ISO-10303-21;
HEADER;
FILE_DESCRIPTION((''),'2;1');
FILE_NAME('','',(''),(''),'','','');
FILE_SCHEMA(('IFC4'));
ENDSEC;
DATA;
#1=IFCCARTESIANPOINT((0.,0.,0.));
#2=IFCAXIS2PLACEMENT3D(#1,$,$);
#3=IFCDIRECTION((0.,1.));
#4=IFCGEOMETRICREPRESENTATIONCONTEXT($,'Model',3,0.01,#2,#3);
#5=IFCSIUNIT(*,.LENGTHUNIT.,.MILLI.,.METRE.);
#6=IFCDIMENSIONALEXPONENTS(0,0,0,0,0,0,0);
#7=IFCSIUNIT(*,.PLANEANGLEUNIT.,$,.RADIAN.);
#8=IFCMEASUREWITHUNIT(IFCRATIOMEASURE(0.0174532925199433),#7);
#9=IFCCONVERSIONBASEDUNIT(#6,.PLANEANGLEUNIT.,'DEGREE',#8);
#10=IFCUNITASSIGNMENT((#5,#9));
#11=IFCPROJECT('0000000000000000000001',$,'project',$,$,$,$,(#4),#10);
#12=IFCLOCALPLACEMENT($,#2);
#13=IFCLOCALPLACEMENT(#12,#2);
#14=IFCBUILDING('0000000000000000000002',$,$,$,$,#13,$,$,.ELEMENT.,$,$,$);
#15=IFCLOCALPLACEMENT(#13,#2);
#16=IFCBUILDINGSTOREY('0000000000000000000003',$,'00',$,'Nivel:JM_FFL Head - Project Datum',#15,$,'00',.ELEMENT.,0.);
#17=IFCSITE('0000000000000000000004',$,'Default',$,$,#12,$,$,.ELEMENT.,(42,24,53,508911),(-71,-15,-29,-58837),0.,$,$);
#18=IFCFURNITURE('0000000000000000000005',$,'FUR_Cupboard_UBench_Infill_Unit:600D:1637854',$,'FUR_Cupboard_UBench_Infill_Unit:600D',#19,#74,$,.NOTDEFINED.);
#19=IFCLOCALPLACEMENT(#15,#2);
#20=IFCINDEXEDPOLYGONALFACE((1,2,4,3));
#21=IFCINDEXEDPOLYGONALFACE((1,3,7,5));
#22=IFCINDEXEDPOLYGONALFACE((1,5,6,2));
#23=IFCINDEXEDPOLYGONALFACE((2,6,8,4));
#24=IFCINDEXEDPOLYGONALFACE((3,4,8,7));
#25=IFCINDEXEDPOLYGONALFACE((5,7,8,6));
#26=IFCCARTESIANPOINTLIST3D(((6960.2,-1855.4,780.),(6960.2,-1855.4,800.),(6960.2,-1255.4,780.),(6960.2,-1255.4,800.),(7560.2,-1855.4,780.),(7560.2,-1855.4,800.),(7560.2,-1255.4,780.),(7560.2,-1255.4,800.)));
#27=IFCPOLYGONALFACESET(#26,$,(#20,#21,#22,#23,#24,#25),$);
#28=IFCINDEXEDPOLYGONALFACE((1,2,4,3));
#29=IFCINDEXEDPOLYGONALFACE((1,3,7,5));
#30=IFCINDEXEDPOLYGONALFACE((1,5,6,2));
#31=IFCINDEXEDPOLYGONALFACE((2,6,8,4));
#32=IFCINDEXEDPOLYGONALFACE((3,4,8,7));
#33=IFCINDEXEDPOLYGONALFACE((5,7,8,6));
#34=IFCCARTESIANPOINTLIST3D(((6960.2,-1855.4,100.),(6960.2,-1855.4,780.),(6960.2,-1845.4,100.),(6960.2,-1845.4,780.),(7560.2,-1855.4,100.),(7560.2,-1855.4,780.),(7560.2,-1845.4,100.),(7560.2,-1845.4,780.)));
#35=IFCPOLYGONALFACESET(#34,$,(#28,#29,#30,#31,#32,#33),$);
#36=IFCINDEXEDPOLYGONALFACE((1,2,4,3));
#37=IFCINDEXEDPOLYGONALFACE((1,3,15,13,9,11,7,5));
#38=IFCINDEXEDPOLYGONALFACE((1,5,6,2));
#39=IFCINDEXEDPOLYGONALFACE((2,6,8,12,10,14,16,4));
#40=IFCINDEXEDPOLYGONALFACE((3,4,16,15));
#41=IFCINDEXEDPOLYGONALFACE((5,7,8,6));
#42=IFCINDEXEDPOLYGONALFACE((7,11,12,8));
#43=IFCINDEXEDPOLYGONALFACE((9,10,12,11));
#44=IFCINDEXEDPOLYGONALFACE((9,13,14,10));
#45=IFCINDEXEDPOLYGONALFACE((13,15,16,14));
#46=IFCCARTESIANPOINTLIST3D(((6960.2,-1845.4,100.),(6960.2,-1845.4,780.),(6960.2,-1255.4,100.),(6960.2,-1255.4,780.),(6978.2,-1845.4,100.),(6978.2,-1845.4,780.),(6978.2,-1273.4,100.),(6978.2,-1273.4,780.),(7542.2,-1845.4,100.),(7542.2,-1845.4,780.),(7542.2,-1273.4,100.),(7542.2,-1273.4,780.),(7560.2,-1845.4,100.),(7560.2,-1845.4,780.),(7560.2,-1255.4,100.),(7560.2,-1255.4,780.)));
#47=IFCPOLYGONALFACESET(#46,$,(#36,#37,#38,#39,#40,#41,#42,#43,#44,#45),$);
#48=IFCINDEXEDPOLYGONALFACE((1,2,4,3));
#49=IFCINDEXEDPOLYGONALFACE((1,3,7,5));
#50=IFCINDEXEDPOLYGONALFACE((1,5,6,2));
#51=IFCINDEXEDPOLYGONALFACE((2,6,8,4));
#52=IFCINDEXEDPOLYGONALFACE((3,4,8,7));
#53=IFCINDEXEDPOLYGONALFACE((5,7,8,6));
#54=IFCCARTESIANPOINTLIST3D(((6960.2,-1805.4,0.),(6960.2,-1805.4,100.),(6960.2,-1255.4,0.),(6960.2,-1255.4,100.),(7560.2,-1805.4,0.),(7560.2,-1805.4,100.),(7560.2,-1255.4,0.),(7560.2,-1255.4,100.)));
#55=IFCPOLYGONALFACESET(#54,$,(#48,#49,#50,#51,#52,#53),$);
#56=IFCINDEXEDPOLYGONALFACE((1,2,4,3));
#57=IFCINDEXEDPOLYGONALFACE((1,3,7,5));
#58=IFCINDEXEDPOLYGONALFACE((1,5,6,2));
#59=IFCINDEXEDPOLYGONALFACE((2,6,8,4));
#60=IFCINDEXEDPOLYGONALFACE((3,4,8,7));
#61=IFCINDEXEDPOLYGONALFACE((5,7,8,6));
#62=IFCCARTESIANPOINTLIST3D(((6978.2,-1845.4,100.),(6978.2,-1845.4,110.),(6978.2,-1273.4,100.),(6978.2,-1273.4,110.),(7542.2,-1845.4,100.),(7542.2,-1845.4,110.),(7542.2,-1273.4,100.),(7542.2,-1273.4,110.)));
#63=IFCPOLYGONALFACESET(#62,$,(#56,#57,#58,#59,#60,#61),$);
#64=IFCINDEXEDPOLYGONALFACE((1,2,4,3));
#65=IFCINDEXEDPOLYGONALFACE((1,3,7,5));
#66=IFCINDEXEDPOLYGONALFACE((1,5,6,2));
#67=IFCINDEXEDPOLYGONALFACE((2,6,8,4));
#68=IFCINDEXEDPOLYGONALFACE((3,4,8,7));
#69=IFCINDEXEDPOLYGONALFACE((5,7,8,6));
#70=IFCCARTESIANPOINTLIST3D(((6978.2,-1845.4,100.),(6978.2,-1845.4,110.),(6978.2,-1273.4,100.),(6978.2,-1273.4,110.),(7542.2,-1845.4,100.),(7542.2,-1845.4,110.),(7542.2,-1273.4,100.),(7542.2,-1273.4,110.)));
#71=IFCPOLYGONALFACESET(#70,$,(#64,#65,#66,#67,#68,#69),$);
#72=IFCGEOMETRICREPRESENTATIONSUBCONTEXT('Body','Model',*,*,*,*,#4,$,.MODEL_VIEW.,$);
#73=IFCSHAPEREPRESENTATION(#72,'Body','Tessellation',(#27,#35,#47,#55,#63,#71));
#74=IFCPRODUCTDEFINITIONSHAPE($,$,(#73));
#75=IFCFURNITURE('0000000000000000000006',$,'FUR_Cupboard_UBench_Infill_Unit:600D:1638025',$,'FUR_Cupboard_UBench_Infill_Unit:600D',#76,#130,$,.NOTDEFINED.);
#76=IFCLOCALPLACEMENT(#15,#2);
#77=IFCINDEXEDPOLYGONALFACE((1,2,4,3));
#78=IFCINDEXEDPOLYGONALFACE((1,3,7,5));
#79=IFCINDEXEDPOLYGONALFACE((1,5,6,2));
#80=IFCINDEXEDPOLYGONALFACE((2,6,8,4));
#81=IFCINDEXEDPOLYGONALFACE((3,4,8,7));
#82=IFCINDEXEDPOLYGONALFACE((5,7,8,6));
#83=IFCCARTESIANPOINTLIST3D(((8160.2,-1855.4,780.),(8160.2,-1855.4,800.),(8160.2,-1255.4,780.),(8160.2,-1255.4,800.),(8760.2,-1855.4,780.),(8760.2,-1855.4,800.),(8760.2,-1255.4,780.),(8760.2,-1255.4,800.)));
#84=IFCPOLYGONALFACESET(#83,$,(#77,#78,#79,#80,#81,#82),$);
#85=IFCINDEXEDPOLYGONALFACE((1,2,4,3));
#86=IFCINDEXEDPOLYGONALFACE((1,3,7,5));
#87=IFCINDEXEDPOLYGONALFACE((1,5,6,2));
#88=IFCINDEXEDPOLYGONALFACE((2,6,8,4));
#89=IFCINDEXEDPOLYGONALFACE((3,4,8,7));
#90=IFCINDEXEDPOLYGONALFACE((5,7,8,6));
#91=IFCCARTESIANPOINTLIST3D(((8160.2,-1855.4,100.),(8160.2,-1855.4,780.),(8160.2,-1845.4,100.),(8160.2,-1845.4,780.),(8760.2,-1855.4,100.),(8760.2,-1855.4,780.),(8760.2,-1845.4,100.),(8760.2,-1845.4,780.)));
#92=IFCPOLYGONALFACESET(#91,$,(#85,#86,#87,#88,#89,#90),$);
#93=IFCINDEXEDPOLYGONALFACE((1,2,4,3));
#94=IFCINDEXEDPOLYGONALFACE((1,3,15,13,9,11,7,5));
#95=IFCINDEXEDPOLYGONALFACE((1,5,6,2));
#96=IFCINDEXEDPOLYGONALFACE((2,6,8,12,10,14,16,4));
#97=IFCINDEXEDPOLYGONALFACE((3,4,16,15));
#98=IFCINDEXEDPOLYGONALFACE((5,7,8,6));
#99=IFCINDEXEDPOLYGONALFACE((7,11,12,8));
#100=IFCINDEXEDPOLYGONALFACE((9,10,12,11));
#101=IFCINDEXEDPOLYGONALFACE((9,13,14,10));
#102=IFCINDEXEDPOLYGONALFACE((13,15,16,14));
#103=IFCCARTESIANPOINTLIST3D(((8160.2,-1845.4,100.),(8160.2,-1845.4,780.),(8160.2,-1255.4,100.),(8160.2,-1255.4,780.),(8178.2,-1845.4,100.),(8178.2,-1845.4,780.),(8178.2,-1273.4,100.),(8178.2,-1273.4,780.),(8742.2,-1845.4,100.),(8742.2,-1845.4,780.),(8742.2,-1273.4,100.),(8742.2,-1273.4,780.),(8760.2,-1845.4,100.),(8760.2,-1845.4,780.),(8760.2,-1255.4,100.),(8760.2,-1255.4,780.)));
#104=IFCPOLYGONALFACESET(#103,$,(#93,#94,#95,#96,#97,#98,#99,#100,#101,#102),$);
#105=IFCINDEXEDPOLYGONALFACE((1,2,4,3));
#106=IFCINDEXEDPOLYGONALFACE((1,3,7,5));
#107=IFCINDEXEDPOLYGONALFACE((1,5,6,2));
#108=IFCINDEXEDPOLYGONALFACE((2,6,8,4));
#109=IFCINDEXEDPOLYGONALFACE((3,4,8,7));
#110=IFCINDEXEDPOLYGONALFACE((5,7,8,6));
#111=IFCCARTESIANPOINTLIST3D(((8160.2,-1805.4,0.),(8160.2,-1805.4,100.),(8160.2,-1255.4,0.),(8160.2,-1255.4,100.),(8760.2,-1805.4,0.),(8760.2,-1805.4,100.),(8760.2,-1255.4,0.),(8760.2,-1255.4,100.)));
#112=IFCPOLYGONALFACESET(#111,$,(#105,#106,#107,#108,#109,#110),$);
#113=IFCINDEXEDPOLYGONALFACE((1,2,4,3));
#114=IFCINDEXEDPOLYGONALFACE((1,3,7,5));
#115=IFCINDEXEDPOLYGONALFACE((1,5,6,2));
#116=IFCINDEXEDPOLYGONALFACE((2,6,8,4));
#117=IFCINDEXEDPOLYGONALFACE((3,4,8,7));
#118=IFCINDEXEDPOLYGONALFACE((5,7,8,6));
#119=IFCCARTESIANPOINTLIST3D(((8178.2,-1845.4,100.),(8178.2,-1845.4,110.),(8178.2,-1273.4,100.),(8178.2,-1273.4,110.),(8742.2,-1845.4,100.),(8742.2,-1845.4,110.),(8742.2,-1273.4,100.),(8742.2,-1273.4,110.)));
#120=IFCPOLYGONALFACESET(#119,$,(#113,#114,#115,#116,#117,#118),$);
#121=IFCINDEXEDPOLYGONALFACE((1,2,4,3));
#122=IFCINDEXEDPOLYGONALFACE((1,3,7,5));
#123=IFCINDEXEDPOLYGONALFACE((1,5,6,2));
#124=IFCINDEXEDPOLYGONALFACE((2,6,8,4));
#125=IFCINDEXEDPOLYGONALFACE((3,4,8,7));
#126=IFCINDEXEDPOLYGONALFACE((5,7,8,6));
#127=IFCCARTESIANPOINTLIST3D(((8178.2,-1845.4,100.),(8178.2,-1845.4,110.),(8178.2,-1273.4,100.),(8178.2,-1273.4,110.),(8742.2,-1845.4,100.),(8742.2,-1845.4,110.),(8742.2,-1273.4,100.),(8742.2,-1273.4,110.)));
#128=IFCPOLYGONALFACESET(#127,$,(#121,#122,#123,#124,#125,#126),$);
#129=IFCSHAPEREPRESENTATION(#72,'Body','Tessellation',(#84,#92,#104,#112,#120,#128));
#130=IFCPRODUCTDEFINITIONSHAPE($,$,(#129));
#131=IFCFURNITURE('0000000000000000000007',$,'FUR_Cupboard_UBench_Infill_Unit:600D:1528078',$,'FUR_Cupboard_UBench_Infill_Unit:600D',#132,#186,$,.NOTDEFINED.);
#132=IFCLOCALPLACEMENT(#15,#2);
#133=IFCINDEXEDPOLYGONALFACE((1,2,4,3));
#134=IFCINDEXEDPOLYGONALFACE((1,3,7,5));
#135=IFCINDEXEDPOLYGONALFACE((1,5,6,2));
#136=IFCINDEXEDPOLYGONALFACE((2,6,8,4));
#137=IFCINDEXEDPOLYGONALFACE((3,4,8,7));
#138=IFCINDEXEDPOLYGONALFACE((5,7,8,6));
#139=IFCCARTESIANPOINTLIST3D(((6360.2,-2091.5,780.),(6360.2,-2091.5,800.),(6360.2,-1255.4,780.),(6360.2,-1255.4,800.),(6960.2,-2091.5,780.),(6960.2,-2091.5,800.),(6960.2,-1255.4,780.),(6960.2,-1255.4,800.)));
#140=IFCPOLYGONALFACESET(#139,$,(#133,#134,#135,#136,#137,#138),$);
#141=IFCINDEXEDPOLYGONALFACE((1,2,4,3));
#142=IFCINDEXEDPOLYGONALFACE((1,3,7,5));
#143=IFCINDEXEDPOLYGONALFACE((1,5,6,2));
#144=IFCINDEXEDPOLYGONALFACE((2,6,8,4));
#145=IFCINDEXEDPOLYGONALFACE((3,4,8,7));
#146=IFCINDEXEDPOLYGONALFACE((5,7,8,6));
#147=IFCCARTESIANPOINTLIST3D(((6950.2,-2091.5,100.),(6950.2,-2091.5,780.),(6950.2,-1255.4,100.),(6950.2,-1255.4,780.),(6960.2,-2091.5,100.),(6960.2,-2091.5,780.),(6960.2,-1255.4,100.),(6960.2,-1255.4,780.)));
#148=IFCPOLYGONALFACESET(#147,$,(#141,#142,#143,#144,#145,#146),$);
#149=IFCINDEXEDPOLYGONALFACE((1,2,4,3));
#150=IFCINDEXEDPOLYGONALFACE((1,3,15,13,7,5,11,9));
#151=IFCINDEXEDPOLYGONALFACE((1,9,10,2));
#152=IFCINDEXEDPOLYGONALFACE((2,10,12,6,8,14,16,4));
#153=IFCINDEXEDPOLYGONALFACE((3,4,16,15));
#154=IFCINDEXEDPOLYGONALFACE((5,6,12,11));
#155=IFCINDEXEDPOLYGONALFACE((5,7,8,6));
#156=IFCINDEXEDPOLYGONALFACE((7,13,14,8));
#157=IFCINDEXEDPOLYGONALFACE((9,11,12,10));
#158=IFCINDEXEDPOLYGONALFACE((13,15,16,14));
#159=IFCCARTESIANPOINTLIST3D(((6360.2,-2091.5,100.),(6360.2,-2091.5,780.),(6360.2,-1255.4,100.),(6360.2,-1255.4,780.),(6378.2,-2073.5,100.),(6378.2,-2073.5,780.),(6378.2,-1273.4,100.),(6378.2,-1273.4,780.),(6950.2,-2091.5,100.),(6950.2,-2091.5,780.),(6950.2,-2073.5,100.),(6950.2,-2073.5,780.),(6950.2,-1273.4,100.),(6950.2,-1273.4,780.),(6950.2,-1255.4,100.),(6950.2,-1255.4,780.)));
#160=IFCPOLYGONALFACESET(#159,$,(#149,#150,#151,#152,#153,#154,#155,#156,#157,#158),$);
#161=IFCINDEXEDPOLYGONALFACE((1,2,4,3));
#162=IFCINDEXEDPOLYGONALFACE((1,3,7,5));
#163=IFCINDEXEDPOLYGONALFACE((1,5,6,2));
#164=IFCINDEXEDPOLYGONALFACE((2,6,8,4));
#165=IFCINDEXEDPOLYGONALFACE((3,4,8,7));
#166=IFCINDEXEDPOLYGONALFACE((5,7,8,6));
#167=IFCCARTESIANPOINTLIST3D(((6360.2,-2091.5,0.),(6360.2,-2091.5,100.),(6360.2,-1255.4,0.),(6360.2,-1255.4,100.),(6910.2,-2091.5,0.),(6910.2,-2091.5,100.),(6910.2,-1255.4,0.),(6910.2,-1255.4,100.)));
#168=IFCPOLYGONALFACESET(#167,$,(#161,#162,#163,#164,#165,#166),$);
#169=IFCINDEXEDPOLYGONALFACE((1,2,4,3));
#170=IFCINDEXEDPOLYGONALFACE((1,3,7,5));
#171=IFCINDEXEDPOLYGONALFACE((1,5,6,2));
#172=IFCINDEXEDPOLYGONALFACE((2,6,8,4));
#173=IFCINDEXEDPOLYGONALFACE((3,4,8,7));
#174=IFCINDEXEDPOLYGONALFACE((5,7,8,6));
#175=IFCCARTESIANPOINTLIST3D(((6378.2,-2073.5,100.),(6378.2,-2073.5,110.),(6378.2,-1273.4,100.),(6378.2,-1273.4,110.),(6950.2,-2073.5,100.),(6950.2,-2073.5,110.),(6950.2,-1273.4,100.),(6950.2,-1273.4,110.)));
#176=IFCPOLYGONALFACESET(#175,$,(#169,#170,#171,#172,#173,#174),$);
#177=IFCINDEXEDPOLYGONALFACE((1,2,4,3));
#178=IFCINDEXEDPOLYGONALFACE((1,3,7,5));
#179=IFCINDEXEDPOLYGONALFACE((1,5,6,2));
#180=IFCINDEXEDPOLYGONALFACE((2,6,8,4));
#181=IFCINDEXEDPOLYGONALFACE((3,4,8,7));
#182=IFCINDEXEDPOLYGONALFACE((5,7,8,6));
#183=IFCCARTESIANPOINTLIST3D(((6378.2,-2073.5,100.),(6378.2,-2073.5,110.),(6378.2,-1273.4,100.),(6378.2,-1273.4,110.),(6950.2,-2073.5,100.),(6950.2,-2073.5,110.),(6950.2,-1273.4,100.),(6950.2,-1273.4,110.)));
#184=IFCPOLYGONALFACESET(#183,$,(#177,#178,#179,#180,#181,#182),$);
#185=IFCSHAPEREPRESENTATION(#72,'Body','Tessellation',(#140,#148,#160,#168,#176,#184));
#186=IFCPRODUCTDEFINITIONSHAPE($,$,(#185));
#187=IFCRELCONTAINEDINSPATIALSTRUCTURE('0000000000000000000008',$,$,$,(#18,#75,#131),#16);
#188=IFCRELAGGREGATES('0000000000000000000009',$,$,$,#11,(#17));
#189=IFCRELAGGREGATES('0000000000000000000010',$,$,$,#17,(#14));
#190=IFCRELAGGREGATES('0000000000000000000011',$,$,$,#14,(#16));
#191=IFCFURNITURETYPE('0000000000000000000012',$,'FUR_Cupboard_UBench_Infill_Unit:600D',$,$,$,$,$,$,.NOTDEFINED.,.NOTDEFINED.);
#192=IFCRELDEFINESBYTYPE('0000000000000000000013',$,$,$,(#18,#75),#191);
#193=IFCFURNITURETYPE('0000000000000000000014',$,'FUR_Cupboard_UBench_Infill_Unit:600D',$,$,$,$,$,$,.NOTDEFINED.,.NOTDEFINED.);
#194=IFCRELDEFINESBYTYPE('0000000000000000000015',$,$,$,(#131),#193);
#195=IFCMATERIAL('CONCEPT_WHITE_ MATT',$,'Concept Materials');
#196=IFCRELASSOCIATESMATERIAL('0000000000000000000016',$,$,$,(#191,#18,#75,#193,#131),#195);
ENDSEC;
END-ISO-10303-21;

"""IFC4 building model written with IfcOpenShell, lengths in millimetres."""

from ifc_helpers import new_model, entity, si_unit, converted_unit, direction, frame, origin, place, context, subcontext, project, spatial, indexed_curve, outline, extrude, source, transform, mapped, material, type_object, type_shapes, element, save


model = new_model("IFC4")

# Units and contexts
model_context = context("Model", 3, precision=0.01, world=origin(), true_north=direction((0.0, 1.0)))
body_context = subcontext(model_context, "Body", "Model", "MODEL_VIEW")
ifc_project = project(units=[si_unit("LENGTHUNIT", "METRE", prefix="MILLI"), converted_unit("PLANEANGLEUNIT", "DEGREE", entity("IfcRatioMeasure", 0.0174532925199433), si_unit("PLANEANGLEUNIT", "RADIAN"), dimensions=[0, 0, 0, 0, 0, 0, 0])], contexts=[model_context])

# Site, building, storey
site_placement = place(None, origin())
site = spatial("IfcSite", under=ifc_project, at=site_placement, Name="Default", CompositionType="ELEMENT", RefLatitude=(42, 24, 53, 508911), RefLongitude=(-71, -15, -29, -58837), RefElevation=0.0)
building_placement = place(site_placement, origin())
building = spatial("IfcBuilding", under=site, at=building_placement, CompositionType="ELEMENT")
storey_placement = place(building_placement, origin())
storey = spatial("IfcBuildingStorey", under=building, at=storey_placement, Name="00", ObjectType="Nivel:JM_FFL Head - Project Datum", LongName="00", CompositionType="ELEMENT", Elevation=0.0)

# Furniture
ifc_material_1 = material(Name="CONCEPT_WHITE_ MATT", Category="Concept Materials")
furniture_type_1 = type_object("IfcFurnitureType", Name="FUR_Cupboard_UBench_Infill_Unit:600D", AssemblyPlace="NOTDEFINED", PredefinedType="NOTDEFINED", material=ifc_material_1)
shared_shape_1 = source(origin(), body_context, "Body", "SweptSolid", [
    extrude(outline(indexed_curve([(-300.0, -300.0), (300.0, -300.0), (300.0, 300.0), (-300.0, 300.0), (-300.0, -300.0)], self_intersect=False)), frame((44.7, 300.0, 780.0), z_axis=(0.0, 0.0, 1.0), x_axis=(0.0, 1.0, 0.0)), (0.0, 0.0, 1.0), 20.0),
    extrude(outline(indexed_curve([(-5.0, -300.0), (5.0, -300.0), (5.0, 300.0), (-5.0, 300.0), (-5.0, -300.0)], self_intersect=False)), frame((44.7, 595.0, 100.0), z_axis=(0.0, 0.0, 1.0), x_axis=(0.0, 1.0, 0.0)), (0.0, 0.0, 1.0), 680.0),
    extrude(outline(indexed_curve([(-299.5, -300.0), (290.5, -300.0), (290.5, -282.0), (-281.5, -282.0), (-281.5, 282.0), (290.5, 282.0), (290.5, 300.0), (-299.5, 300.0), (-299.5, -300.0)], self_intersect=False)), frame((44.7, 299.5, 100.0), z_axis=(0.0, 0.0, 1.0), x_axis=(0.0, 1.0, 0.0)), (0.0, 0.0, 1.0), 680.0),
    extrude(outline(indexed_curve([(-275.0, -300.0), (275.0, -300.0), (275.0, 300.0), (-275.0, 300.0), (-275.0, -300.0)], self_intersect=False)), frame((44.7, 275.0, 0.0), z_axis=(0.0, 0.0, 1.0), x_axis=(0.0, 1.0, 0.0)), (0.0, 0.0, 1.0), 100.0),
    extrude(outline(indexed_curve([(-286.0, -282.0), (286.0, -282.0), (286.0, 282.0), (-286.0, 282.0), (-286.0, -282.0)], self_intersect=False)), frame((44.7, 304.0, 100.0), z_axis=(0.0, 0.0, 1.0), x_axis=(0.0, 1.0, 0.0)), (0.0, 0.0, 1.0), 10.0),
    extrude(outline(indexed_curve([(-286.0, -282.0), (286.0, -282.0), (286.0, 282.0), (-286.0, 282.0), (-286.0, -282.0)], self_intersect=False)), frame((44.7, 304.0, 100.0), z_axis=(0.0, 0.0, 1.0), x_axis=(0.0, 1.0, 0.0)), (0.0, 0.0, 1.0), 10.0),
])
type_shapes(furniture_type_1, [shared_shape_1])
for number, where, z_axis, x_axis, name in (
    (1, (7304.9, -1255.4, 0.0), (0.0, 0.0, 1.0), (-1.0, 0.0, 0.0), "FUR_Cupboard_UBench_Infill_Unit:600D:1637854"),
    (2, (8504.9, -1255.4, 0.0), (0.0, 0.0, 1.0), (-1.0, 0.0, 0.0), "FUR_Cupboard_UBench_Infill_Unit:600D:1638025"),
):
    element("IfcFurniture", number, at=place(storey_placement, frame(where, z_axis=z_axis, x_axis=x_axis)), inside=storey, type_object=furniture_type_1, material=ifc_material_1, Name=name, ObjectType="FUR_Cupboard_UBench_Infill_Unit:600D", PredefinedType="NOTDEFINED", context=body_context, shape_type="MappedRepresentation", body=[
        mapped(shared_shape_1, transform((0.0, 0.0, 0.0), scale=1.0)),
    ])
furniture_type_2 = type_object("IfcFurnitureType", Name="FUR_Cupboard_UBench_Infill_Unit:600D", AssemblyPlace="NOTDEFINED", PredefinedType="NOTDEFINED", material=ifc_material_1)
shared_shape_2 = source(origin(), body_context, "Body", "SweptSolid", [
    extrude(outline(indexed_curve([(-418.0, -300.0), (418.0, -300.0), (418.0, 300.0), (-418.0, 300.0), (-418.0, -300.0)], self_intersect=False)), frame((44.7, -300.0, 780.0), z_axis=(0.0, 0.0, 1.0), x_axis=(-1.0, 0.0, 0.0)), (0.0, 0.0, 1.0), 20.0),
    extrude(outline(indexed_curve([(-418.0, -5.0), (418.0, -5.0), (418.0, 5.0), (-418.0, 5.0), (-418.0, -5.0)], self_intersect=False)), frame((44.7, -595.0, 100.0), z_axis=(0.0, 0.0, 1.0), x_axis=(-1.0, 0.0, 0.0)), (0.0, 0.0, 1.0), 680.0),
    extrude(outline(indexed_curve([(-418.0, -299.5), (418.0, -299.5), (418.0, 290.5), (400.0, 290.5), (400.0, -281.5), (-400.0, -281.5), (-400.0, 290.5), (-418.0, 290.5), (-418.0, -299.5)], self_intersect=False)), frame((44.7, -299.5, 100.0), z_axis=(0.0, 0.0, 1.0), x_axis=(-1.0, 0.0, 0.0)), (0.0, 0.0, 1.0), 680.0),
    extrude(outline(indexed_curve([(-418.0, -275.0), (418.0, -275.0), (418.0, 275.0), (-418.0, 275.0), (-418.0, -275.0)], self_intersect=False)), frame((44.7, -275.0, 0.0), z_axis=(0.0, 0.0, 1.0), x_axis=(-1.0, 0.0, 0.0)), (0.0, 0.0, 1.0), 100.0),
    extrude(outline(indexed_curve([(-400.0, -286.0), (400.0, -286.0), (400.0, 286.0), (-400.0, 286.0), (-400.0, -286.0)], self_intersect=False)), frame((44.7, -304.0, 100.0), z_axis=(0.0, 0.0, 1.0), x_axis=(-1.0, 0.0, 0.0)), (0.0, 0.0, 1.0), 10.0),
    extrude(outline(indexed_curve([(-400.0, -286.0), (400.0, -286.0), (400.0, 286.0), (-400.0, 286.0), (-400.0, -286.0)], self_intersect=False)), frame((44.7, -304.0, 100.0), z_axis=(0.0, 0.0, 1.0), x_axis=(-1.0, 0.0, 0.0)), (0.0, 0.0, 1.0), 10.0),
])
type_shapes(furniture_type_2, [shared_shape_2])
furniture_1_placement = place(storey_placement, frame((6360.2, -1718.2, 0.0), z_axis=(0.0, 0.0, 1.0), x_axis=(0.0, 1.0, 0.0)))
element("IfcFurniture", 3, at=furniture_1_placement, inside=storey, type_object=furniture_type_2, material=ifc_material_1, Name="FUR_Cupboard_UBench_Infill_Unit:600D:1528078", ObjectType="FUR_Cupboard_UBench_Infill_Unit:600D", PredefinedType="NOTDEFINED", context=body_context, shape_type="MappedRepresentation", body=[
    mapped(shared_shape_2, transform((0.0, 0.0, 0.0), scale=1.0)),
])

save(model, "model.ifc")
